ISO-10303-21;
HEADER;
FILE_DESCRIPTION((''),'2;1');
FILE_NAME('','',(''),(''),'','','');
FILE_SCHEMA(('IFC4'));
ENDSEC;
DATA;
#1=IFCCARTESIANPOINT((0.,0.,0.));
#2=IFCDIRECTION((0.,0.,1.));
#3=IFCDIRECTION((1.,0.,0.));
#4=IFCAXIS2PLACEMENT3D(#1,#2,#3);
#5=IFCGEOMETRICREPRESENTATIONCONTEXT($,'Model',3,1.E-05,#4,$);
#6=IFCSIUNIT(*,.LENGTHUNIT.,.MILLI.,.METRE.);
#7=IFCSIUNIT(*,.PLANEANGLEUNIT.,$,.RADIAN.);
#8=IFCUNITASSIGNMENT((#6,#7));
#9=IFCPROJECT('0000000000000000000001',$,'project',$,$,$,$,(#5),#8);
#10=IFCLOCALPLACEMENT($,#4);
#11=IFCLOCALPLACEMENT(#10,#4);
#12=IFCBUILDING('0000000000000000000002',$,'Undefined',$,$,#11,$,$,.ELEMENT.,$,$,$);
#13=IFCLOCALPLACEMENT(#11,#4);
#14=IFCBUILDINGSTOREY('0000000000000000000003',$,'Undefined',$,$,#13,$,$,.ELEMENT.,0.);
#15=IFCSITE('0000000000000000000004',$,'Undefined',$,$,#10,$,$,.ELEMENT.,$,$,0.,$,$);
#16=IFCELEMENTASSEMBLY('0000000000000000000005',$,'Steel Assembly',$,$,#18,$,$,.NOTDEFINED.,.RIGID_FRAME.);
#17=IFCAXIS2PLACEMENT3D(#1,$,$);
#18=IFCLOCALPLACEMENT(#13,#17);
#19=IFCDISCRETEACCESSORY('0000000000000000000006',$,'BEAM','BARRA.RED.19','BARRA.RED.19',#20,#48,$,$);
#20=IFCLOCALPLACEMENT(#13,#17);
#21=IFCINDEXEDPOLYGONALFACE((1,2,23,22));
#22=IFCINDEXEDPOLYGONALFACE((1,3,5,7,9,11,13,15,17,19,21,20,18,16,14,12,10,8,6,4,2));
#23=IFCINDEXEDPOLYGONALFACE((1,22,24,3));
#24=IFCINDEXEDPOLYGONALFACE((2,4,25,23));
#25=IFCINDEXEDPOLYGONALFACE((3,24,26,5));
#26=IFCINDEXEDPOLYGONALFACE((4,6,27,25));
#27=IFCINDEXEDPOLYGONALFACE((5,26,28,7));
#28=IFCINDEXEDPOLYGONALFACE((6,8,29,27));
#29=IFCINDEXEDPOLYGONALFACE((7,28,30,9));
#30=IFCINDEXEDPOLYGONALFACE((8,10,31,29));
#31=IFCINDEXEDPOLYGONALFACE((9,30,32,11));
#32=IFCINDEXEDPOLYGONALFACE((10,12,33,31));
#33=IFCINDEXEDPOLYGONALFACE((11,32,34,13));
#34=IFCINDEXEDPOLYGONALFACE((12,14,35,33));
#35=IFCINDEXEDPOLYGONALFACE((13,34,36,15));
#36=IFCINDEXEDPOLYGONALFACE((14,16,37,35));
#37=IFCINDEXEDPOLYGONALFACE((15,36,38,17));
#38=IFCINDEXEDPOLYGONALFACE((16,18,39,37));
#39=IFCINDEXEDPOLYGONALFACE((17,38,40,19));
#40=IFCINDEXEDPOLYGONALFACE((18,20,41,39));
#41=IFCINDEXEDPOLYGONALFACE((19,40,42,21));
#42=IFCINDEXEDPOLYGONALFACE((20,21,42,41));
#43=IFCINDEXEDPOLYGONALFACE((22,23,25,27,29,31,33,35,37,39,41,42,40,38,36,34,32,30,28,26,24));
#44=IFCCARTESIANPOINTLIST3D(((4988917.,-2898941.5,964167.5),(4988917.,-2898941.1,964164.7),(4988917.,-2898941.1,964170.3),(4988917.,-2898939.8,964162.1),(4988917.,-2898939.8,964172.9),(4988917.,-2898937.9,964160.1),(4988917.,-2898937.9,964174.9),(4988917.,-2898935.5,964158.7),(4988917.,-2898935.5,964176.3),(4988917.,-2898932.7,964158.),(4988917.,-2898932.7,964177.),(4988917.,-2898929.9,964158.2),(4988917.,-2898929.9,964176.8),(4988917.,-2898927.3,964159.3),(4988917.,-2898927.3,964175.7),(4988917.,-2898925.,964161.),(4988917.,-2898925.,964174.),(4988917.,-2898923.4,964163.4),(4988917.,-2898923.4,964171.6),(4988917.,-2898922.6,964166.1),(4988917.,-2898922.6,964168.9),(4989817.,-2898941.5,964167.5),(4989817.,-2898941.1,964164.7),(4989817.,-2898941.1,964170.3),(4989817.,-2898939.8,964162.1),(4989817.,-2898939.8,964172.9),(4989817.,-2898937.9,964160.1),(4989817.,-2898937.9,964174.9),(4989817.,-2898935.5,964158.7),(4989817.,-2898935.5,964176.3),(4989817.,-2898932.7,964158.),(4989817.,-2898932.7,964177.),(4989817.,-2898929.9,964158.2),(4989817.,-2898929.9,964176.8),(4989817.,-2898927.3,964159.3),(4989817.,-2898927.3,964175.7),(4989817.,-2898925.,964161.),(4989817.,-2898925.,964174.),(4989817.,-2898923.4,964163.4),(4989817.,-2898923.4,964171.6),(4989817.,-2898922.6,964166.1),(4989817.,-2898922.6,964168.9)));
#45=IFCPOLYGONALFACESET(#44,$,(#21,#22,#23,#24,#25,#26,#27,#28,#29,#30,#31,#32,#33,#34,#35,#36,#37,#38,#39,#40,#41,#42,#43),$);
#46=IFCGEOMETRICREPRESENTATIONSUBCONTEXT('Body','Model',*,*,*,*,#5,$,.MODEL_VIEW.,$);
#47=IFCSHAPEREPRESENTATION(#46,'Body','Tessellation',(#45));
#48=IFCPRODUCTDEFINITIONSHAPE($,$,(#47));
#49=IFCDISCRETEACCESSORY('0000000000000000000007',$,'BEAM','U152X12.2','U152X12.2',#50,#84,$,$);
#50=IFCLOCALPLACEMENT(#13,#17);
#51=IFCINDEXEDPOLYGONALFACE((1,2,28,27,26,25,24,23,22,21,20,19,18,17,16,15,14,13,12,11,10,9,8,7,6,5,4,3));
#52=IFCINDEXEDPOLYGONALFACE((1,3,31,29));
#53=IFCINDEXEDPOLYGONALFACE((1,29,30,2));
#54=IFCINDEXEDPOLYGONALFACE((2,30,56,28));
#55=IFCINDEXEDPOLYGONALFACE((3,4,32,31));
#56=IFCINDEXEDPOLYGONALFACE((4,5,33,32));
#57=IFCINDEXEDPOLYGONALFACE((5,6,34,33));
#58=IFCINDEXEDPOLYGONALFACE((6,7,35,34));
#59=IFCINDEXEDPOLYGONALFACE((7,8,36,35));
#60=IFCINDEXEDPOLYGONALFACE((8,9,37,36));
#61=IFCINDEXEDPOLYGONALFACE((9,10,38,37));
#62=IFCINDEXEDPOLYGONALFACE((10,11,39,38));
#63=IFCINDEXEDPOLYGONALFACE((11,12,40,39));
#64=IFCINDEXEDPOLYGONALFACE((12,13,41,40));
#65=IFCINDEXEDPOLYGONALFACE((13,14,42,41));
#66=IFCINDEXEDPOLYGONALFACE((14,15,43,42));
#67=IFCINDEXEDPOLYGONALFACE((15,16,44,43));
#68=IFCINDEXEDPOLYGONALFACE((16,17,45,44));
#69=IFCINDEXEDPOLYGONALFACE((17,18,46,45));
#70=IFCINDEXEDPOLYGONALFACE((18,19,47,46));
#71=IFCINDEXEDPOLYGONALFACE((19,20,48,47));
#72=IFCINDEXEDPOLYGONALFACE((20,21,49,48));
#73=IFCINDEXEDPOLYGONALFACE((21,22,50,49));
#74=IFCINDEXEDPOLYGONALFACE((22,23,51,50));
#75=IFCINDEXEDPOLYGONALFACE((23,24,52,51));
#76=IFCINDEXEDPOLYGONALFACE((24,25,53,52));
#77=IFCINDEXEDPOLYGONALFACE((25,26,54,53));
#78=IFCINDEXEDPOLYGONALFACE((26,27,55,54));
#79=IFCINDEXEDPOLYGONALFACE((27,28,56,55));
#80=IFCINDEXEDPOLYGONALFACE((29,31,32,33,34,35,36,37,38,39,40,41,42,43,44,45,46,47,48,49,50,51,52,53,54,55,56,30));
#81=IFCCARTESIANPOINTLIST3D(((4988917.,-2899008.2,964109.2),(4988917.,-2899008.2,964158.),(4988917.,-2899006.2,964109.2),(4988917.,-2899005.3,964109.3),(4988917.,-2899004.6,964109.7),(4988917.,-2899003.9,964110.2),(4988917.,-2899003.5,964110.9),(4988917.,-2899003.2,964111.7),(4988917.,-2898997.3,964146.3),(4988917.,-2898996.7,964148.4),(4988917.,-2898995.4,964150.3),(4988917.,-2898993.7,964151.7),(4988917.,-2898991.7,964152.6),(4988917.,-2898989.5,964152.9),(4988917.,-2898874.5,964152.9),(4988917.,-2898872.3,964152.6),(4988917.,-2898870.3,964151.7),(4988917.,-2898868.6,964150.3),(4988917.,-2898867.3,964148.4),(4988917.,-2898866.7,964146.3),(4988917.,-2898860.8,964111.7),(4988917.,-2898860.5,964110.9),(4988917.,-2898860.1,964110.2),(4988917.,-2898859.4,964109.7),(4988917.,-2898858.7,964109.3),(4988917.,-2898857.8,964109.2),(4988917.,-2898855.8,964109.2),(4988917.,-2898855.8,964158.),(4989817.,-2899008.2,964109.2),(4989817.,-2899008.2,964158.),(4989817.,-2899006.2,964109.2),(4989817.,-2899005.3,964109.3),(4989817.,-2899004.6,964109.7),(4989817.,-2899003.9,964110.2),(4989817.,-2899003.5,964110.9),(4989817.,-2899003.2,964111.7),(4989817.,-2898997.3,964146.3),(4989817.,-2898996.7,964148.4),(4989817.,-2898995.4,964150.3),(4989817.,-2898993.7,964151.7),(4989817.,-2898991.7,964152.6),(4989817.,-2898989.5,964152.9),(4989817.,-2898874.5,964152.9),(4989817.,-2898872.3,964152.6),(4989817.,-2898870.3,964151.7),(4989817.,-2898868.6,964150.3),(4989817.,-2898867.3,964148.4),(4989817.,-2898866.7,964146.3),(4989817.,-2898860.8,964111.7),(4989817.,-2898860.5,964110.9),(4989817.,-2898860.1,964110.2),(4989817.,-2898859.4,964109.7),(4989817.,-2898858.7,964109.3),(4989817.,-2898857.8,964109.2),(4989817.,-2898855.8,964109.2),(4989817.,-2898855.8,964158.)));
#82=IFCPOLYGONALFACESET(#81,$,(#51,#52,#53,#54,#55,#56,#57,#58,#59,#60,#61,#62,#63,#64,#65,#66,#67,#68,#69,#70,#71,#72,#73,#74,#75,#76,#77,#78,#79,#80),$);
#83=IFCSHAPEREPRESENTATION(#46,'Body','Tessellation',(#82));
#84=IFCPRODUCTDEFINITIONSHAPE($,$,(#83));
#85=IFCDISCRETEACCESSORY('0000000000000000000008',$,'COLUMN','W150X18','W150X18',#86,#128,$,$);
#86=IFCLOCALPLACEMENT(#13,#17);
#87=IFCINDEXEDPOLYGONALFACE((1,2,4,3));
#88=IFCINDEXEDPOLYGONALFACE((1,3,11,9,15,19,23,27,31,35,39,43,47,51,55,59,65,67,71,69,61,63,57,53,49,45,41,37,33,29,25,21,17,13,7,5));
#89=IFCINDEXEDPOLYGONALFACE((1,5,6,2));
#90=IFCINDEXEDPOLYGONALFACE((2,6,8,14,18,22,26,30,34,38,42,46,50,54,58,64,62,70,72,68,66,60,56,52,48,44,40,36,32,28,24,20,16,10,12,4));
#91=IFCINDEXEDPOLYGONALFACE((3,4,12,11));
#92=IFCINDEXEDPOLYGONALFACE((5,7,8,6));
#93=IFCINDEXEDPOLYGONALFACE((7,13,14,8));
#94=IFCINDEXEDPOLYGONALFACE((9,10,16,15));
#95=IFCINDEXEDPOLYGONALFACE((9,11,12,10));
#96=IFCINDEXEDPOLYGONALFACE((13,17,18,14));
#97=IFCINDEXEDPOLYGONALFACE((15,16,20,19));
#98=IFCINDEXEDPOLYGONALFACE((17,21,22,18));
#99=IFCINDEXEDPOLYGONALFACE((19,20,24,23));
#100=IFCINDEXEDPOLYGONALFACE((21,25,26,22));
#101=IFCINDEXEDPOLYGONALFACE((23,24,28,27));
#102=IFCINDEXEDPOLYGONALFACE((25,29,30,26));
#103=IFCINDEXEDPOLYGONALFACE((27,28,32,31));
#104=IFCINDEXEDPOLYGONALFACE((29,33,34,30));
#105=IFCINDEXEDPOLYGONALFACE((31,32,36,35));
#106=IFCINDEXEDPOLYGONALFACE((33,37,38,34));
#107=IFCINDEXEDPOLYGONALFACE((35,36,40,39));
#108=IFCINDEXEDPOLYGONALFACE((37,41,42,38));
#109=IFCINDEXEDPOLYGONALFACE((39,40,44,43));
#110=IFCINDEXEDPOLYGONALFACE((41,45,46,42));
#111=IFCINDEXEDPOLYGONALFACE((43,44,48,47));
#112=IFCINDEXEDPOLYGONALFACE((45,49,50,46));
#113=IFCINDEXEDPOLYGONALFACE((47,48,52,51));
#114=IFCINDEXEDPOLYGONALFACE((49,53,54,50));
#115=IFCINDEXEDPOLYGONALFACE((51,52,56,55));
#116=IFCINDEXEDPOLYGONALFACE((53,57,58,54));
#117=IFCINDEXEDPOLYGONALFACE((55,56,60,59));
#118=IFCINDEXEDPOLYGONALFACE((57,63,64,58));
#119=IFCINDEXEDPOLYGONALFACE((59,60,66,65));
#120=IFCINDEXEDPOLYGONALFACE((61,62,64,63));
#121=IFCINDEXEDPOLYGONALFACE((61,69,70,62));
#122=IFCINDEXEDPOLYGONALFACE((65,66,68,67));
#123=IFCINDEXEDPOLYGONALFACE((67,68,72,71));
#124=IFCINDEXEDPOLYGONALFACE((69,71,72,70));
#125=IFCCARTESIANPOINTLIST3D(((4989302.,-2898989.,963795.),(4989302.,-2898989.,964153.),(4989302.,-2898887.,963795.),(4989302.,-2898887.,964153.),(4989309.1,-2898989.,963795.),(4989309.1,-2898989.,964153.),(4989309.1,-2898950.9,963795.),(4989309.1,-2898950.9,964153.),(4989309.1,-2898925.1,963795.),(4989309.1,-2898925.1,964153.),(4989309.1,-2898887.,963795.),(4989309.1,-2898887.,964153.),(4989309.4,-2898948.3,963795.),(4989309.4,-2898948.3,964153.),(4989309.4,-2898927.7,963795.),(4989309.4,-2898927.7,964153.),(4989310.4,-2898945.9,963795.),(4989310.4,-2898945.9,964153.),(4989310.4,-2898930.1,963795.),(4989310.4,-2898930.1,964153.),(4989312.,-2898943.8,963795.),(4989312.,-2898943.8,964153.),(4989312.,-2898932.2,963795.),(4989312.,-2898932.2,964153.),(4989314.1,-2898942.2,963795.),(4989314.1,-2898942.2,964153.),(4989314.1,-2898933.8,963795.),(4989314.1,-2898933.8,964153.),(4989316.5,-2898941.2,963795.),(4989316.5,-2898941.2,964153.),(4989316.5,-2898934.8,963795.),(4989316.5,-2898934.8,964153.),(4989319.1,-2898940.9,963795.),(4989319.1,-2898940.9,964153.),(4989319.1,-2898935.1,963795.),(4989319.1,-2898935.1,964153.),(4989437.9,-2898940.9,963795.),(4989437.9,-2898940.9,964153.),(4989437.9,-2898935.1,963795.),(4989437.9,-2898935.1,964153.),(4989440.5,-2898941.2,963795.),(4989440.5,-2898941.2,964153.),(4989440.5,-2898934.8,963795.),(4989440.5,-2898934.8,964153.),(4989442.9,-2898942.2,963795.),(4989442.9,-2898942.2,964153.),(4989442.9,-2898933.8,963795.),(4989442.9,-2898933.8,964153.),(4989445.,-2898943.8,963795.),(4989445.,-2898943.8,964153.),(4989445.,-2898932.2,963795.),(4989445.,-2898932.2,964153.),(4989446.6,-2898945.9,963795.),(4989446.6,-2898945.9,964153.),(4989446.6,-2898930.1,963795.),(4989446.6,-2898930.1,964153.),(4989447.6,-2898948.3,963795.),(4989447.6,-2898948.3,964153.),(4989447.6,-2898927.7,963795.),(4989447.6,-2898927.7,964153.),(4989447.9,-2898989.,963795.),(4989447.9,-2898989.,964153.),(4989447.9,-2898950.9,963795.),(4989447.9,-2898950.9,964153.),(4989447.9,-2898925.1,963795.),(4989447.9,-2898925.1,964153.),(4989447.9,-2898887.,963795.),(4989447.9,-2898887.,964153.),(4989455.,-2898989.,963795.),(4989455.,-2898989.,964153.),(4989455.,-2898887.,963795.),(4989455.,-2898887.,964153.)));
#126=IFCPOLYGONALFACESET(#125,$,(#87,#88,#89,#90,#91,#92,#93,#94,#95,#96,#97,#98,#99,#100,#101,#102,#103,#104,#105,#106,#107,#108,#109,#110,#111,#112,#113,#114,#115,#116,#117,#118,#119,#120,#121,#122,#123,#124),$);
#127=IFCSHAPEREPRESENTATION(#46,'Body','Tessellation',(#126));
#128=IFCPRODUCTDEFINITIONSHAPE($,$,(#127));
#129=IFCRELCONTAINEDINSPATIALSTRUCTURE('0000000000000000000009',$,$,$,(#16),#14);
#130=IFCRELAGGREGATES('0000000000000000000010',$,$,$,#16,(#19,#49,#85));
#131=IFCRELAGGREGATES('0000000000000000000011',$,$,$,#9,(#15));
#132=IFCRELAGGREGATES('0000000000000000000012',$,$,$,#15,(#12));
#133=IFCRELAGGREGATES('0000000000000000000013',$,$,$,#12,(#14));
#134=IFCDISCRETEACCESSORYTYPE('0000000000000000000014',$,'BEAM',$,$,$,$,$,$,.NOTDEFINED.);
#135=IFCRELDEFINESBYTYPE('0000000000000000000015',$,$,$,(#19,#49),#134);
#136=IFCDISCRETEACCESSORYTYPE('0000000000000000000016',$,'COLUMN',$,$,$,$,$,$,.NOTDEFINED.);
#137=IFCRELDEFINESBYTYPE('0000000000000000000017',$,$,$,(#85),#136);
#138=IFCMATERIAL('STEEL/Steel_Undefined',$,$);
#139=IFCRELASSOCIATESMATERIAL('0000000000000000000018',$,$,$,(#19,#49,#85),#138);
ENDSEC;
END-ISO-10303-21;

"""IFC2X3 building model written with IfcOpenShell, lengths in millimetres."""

from ifc_helpers import new_model, si_unit, frame, origin_with_axes, origin_2d_with_axis, place, context, subcontext, project, spatial, circle, i_section, u_section, extrude, material, type_object, element, aggregate, save


model = new_model("IFC2X3")

# Units and contexts
model_context = context("Model", 3, precision=1e-05, world=origin_with_axes())
body_context = subcontext(model_context, "Body", "Model", "MODEL_VIEW")
ifc_project = project(units=[si_unit("LENGTHUNIT", "METRE", prefix="MILLI"), si_unit("PLANEANGLEUNIT", "RADIAN")], contexts=[model_context])

# Site, building, storey
site_placement = place(None, origin_with_axes())
site = spatial("IfcSite", under=ifc_project, at=site_placement, Name="Undefined", CompositionType="ELEMENT", RefElevation=0.0)
building_placement = place(site_placement, origin_with_axes())
building = spatial("IfcBuilding", under=site, at=building_placement, Name="Undefined", CompositionType="ELEMENT")
storey_placement = place(building_placement, origin_with_axes())
storey = spatial("IfcBuildingStorey", under=building, at=storey_placement, Name="Undefined", CompositionType="ELEMENT", Elevation=0.0)

# Element assembly
assembly_1_placement = place(storey_placement, origin_with_axes())
assembly_1 = element("IfcElementAssembly", 1, at=assembly_1_placement, inside=storey, Name="Steel Assembly", AssemblyPlace="NOTDEFINED", PredefinedType="RIGID_FRAME")

# Discrete accessories
ifc_material_1 = material(Name="STEEL/Steel_Undefined")
discrete_accessory_type_1 = type_object("IfcDiscreteAccessoryType", Name="BEAM")
discrete_accessory_1_placement = place(assembly_1_placement, frame((4989817.0, -2898932.0, 964167.5), z_axis=(0.0, 0.0, -1.0), x_axis=(-1.0, 0.0, 0.0)))
discrete_accessory_1 = element("IfcDiscreteAccessory", 2, at=discrete_accessory_1_placement, type_object=discrete_accessory_type_1, material=ifc_material_1, Name="BEAM", Description="BARRA.RED.19", ObjectType="BARRA.RED.19", context=body_context, shape_type="SweptSolid", body=[
    extrude(circle(Radius=9.5, at=origin_2d_with_axis()), frame((900.0, 0.0, 0.0), z_axis=(-1.0, 0.0, 0.0), x_axis=(0.0, -1.0, 0.0)), (0.0, 0.0, 1.0), 900.0),
])
discrete_accessory_2_placement = place(assembly_1_placement, frame((4989817.0, -2898932.0, 964133.6), z_axis=(0.0, 1.0, 0.0), x_axis=(-1.0, 0.0, 0.0)))
discrete_accessory_2 = element("IfcDiscreteAccessory", 3, at=discrete_accessory_2_placement, type_object=discrete_accessory_type_1, material=ifc_material_1, Name="BEAM", Description="U152X12.2", ObjectType="U152X12.2", context=body_context, shape_type="SweptSolid", body=[
    extrude(u_section(Depth=152.4, FlangeWidth=48.8, WebThickness=5.1, FlangeThickness=8.7, FilletRadius=8.0, EdgeRadius=3.0, FlangeSlope=0.16839, at=origin_2d_with_axis()), frame((900.0, 0.0, 0.0), z_axis=(-1.0, 0.0, 0.0), x_axis=(0.0, -1.0, 0.0)), (0.0, 0.0, 1.0), 900.0),
])
discrete_accessory_type_2 = type_object("IfcDiscreteAccessoryType", Name="COLUMN")
discrete_accessory_3_placement = place(assembly_1_placement, frame((4989378.5, -2898938.0, 963795.0), z_axis=(0.0, 0.0, 1.0), x_axis=(-1.0, 0.0, 0.0)))
discrete_accessory_3 = element("IfcDiscreteAccessory", 4, at=discrete_accessory_3_placement, type_object=discrete_accessory_type_2, material=ifc_material_1, Name="COLUMN", Description="W150X18", ObjectType="W150X18", context=body_context, shape_type="SweptSolid", body=[
    extrude(i_section(OverallWidth=102.0, OverallDepth=153.0, WebThickness=5.8, FlangeThickness=7.1, FilletRadius=10.0, at=origin_2d_with_axis()), frame((0.0, 0.0, 358.0), z_axis=(0.0, 0.0, -1.0), x_axis=(0.0, 1.0, 0.0)), (0.0, 0.0, 1.0), 358.0),
])
aggregate(assembly_1, [discrete_accessory_1, discrete_accessory_2, discrete_accessory_3])

save(model, "model.ifc")
